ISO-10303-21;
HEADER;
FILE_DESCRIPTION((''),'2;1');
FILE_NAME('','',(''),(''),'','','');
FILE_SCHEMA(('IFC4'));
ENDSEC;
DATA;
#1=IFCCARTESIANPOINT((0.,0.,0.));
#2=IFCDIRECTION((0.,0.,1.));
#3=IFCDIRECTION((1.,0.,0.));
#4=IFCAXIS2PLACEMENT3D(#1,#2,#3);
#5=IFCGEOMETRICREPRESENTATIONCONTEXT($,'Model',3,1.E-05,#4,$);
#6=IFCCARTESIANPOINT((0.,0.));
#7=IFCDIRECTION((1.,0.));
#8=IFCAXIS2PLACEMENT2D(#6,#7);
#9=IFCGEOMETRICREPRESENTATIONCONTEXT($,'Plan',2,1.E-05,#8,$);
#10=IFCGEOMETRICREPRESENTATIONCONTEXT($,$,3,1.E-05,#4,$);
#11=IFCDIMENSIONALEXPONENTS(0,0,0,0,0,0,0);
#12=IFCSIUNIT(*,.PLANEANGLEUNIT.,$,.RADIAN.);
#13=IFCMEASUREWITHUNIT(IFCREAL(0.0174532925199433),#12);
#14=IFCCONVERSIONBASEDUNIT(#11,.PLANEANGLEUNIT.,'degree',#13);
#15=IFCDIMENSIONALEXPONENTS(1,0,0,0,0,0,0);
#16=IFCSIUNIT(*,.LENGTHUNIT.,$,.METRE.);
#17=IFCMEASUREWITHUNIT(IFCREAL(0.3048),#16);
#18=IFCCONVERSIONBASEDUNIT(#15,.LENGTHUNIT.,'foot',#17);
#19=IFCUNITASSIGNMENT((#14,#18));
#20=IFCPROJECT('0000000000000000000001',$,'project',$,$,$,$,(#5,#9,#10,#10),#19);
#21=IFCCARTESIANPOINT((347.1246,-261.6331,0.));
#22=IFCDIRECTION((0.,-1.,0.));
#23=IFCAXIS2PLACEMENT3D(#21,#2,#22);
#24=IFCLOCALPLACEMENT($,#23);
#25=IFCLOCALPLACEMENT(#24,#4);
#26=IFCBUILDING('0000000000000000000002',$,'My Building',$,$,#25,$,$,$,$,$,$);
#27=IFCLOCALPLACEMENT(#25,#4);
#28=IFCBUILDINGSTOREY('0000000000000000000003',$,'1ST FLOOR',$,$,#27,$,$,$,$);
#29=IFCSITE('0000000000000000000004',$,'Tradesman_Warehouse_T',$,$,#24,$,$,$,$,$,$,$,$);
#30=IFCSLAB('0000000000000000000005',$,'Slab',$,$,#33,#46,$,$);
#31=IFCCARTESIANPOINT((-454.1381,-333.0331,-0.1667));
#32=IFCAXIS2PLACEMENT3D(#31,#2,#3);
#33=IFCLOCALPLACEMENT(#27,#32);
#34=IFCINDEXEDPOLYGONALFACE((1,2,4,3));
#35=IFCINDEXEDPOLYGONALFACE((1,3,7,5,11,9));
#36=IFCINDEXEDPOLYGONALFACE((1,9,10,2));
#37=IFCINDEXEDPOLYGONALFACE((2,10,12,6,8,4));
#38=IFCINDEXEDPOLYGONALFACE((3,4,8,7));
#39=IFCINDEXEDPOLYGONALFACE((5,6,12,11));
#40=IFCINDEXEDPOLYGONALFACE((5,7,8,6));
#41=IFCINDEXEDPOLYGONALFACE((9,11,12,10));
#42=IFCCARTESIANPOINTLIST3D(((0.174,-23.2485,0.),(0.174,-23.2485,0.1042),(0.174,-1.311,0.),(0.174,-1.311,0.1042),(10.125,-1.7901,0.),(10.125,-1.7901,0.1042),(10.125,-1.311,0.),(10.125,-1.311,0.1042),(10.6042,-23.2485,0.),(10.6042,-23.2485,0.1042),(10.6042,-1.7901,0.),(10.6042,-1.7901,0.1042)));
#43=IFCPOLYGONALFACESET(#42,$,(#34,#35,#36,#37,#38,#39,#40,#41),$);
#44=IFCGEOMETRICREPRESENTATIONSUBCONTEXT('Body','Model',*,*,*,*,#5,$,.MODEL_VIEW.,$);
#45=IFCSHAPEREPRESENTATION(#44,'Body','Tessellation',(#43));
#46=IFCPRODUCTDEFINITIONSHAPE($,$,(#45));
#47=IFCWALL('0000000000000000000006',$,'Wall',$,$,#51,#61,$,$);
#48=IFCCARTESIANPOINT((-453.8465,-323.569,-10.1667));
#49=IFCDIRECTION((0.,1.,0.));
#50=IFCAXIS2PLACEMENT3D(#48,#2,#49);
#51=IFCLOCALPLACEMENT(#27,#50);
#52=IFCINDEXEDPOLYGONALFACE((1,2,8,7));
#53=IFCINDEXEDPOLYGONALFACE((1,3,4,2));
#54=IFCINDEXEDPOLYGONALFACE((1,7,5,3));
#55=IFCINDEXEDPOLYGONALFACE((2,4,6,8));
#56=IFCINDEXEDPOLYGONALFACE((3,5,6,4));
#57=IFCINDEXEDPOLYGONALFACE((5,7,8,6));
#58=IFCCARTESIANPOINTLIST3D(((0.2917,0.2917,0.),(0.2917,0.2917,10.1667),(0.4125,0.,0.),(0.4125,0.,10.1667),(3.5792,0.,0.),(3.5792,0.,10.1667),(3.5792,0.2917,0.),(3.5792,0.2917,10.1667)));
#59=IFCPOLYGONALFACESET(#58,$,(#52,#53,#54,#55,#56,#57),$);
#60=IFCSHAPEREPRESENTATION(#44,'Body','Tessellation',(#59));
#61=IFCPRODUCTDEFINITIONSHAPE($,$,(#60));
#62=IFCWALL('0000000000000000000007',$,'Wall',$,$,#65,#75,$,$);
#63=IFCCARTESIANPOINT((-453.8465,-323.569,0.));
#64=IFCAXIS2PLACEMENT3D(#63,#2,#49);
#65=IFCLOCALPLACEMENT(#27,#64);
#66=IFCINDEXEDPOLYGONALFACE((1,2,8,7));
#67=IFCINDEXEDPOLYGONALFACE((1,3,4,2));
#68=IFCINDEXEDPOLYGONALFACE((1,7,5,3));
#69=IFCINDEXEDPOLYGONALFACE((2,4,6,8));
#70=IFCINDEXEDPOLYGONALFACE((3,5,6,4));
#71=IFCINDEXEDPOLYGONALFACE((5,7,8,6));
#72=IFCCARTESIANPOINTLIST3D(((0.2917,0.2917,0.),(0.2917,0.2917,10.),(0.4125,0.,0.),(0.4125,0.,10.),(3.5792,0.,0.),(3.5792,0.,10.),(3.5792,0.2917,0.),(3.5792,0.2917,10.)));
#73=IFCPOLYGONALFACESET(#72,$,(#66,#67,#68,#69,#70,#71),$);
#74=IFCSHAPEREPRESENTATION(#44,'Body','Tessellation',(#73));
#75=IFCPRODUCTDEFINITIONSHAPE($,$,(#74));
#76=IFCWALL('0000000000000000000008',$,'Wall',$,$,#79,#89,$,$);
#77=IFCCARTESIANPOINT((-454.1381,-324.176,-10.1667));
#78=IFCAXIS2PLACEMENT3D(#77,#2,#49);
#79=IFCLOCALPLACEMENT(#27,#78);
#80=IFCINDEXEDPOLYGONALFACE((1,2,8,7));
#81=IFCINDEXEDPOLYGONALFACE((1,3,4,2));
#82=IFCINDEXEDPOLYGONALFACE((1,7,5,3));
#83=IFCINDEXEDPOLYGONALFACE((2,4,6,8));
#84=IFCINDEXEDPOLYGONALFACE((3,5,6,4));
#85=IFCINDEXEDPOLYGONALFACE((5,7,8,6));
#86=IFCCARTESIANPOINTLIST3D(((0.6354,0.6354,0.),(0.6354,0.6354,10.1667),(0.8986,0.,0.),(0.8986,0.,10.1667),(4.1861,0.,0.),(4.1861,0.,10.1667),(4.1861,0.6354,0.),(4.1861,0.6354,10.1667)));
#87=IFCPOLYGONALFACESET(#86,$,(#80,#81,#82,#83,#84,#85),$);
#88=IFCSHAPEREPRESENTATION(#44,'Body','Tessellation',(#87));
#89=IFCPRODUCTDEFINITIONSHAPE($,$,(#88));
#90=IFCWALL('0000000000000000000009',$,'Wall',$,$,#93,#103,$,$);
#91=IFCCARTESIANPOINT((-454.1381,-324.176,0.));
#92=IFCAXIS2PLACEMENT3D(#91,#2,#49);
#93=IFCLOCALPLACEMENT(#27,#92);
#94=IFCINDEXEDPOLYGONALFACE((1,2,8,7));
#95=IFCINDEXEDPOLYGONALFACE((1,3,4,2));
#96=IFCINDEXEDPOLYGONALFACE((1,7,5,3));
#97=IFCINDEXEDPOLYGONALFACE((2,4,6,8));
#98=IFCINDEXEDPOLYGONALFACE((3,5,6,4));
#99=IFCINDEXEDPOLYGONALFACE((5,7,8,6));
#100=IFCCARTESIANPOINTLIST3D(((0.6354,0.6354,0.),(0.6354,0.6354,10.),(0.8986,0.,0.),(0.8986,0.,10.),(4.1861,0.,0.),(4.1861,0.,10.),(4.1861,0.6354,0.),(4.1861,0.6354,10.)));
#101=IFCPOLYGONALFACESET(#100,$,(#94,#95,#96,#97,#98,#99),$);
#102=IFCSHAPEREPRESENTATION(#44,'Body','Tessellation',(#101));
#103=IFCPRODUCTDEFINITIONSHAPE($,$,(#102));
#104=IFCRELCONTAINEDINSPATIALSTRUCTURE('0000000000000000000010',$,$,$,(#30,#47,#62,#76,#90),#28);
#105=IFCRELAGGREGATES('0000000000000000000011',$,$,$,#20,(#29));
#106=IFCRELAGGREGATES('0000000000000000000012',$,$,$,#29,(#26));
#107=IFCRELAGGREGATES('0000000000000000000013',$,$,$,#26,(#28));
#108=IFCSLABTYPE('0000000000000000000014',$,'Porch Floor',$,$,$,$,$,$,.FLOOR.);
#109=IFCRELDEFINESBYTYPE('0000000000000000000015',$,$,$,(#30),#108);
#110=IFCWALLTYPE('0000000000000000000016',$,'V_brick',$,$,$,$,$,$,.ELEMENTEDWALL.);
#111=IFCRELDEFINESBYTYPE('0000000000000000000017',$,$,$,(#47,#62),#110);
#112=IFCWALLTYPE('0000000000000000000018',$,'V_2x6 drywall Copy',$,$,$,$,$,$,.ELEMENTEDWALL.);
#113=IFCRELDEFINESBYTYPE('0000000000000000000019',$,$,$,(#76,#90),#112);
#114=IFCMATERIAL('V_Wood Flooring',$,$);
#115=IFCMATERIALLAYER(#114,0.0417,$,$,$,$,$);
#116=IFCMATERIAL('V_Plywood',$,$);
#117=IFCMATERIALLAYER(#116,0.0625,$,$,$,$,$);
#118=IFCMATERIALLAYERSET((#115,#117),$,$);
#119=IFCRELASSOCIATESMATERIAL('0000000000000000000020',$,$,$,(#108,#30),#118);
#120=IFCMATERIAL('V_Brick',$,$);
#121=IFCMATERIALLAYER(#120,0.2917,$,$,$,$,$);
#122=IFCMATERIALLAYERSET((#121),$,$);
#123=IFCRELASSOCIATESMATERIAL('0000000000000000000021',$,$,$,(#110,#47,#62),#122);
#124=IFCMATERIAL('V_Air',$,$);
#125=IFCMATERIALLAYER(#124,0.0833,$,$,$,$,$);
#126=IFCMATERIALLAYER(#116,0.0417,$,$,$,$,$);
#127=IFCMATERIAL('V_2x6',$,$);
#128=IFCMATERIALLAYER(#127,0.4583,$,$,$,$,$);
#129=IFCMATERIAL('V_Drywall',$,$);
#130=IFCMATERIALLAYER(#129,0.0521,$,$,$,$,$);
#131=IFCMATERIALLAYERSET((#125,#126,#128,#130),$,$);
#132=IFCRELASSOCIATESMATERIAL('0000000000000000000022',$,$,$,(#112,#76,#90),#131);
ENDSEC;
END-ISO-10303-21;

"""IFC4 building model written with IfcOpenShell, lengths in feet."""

from ifc_helpers import new_model, entity, si_unit, converted_unit, frame, origin_with_axes, origin_2d_with_axis, place, context, subcontext, project, spatial, indexed_curve, outline, extrude, clip, halfspace, material, layer, layer_set, layer_usage, type_object, element, save


model = new_model("IFC4")

# Units and contexts
model_context = context("Model", 3, precision=1e-05, world=origin_with_axes())
plan_context = context("Plan", 2, precision=1e-05, world=origin_2d_with_axis())
context_of_model = context(None, 3, precision=1e-05, world=origin_with_axes())
body_context = subcontext(model_context, "Body", "Model", "MODEL_VIEW")
ifc_project = project(units=[converted_unit("PLANEANGLEUNIT", "degree", entity("IfcReal", 0.0174532925199433), si_unit("PLANEANGLEUNIT", "RADIAN"), dimensions=[0, 0, 0, 0, 0, 0, 0]), converted_unit("LENGTHUNIT", "foot", entity("IfcReal", 0.3048), si_unit("LENGTHUNIT", "METRE"), dimensions=[1, 0, 0, 0, 0, 0, 0])], contexts=[model_context, plan_context, context_of_model, context_of_model])

# Site, building, storey
site_placement = place(None, frame((347.1246, -261.6331, 0.0), z_axis=(0.0, 0.0, 1.0), x_axis=(0.0, -1.0, 0.0)))
site = spatial("IfcSite", under=ifc_project, at=site_placement, Name="Tradesman_Warehouse_T")
building_placement = place(site_placement, frame((0.0, 0.0, 0.0), z_axis=(0.0, 0.0, 1.0), x_axis=(1.0, 0.0, 0.0)))
building = spatial("IfcBuilding", under=site, at=building_placement, Name="My Building")
storey_placement = place(building_placement, frame((0.0, 0.0, 0.0), z_axis=(0.0, 0.0, 1.0), x_axis=(1.0, 0.0, 0.0)))
storey = spatial("IfcBuildingStorey", under=building, at=storey_placement, Name="1ST FLOOR")

# Slab
ifc_material_1 = material(Name="V_Wood Flooring")
ifc_layer_1 = layer(ifc_material_1, 0.0417)
ifc_material_2 = material(Name="V_Plywood")
ifc_layer_2 = layer(ifc_material_2, 0.0625)
ifc_layer_set_1 = layer_set([ifc_layer_1, ifc_layer_2])
ifc_layer_usage_1 = layer_usage(ifc_layer_set_1, "AXIS3", "POSITIVE", 0.0)
slab_type = type_object("IfcSlabType", Name="Porch Floor", PredefinedType="FLOOR", material=ifc_layer_set_1)
slab_placement = place(storey_placement, frame((-454.1381, -333.0331, -0.1667), z_axis=(0.0, 0.0, 1.0), x_axis=(1.0, 0.0, 0.0)))
element("IfcSlab", 1, at=slab_placement, inside=storey, type_object=slab_type, material=ifc_layer_usage_1, Name="Slab", context=body_context, shape_type="SweptSolid", body=[
    extrude(outline(indexed_curve([(10.125, -1.311), (0.174, -1.311), (0.174, -23.2485), (10.6042, -23.2485), (10.6042, -1.7901), (10.125, -1.7901), (10.125, -1.311)])), None, (0.0, 0.0, 1.0), 0.1042),
])

# Walls
ifc_material_3 = material(Name="V_Brick")
ifc_layer_3 = layer(ifc_material_3, 0.2917)
ifc_layer_set_2 = layer_set([ifc_layer_3])
ifc_layer_usage_2 = layer_usage(ifc_layer_set_2, "AXIS2", "POSITIVE", 0.0)
wall_type_1 = type_object("IfcWallType", Name="V_brick", PredefinedType="ELEMENTEDWALL", material=ifc_layer_set_2)
wall_1_placement = place(storey_placement, frame((-453.8465, -323.569, -10.1667), z_axis=(0.0, 0.0, 1.0), x_axis=(0.0, 1.0, 0.0)))
element("IfcWall", 2, at=wall_1_placement, inside=storey, type_object=wall_type_1, material=ifc_layer_usage_2, Name="Wall", context=body_context, shape_type="Clipping", body=[
    clip(extrude(outline(indexed_curve([(0.0, 0.0), (0.0, 0.2917), (3.5792, 0.2917), (3.5792, 0.0), (0.0, 0.0)], self_intersect=False)), origin_with_axes(), (0.0, 0.0, 1.0), 10.1667), halfspace(frame((0.4125, 0.0, 10.1667), z_axis=(-0.923871, -0.382705, 0.0), x_axis=(-0.382705, 0.923871, 0.0)), False)),
])
ifc_layer_usage_3 = layer_usage(ifc_layer_set_2, "AXIS2", "POSITIVE", 0.0)
wall_2_placement = place(storey_placement, frame((-453.8465, -323.569, 0.0), z_axis=(0.0, 0.0, 1.0), x_axis=(0.0, 1.0, 0.0)))
element("IfcWall", 3, at=wall_2_placement, inside=storey, type_object=wall_type_1, material=ifc_layer_usage_3, Name="Wall", context=body_context, shape_type="Clipping", body=[
    clip(extrude(outline(indexed_curve([(0.0, 0.0), (0.0, 0.2917), (3.5792, 0.2917), (3.5792, 0.0), (0.0, 0.0)], self_intersect=False)), origin_with_axes(), (0.0, 0.0, 1.0), 10.0), halfspace(frame((0.4125, 0.0, 0.0), z_axis=(-0.923871, -0.382705, 0.0), x_axis=(-0.382705, 0.923871, 0.0)), False)),
])
ifc_material_4 = material(Name="V_Air")
ifc_layer_4 = layer(ifc_material_4, 0.0833)
ifc_layer_5 = layer(ifc_material_2, 0.0417)
ifc_material_5 = material(Name="V_2x6")
ifc_layer_6 = layer(ifc_material_5, 0.4583)
ifc_material_6 = material(Name="V_Drywall")
ifc_layer_7 = layer(ifc_material_6, 0.0521)
ifc_layer_set_3 = layer_set([ifc_layer_4, ifc_layer_5, ifc_layer_6, ifc_layer_7])
ifc_layer_usage_4 = layer_usage(ifc_layer_set_3, "AXIS2", "POSITIVE", 0.0)
wall_type_2 = type_object("IfcWallType", Name="V_2x6 drywall Copy", PredefinedType="ELEMENTEDWALL", material=ifc_layer_set_3)
wall_3_placement = place(storey_placement, frame((-454.1381, -324.176, -10.1667), z_axis=(0.0, 0.0, 1.0), x_axis=(0.0, 1.0, 0.0)))
element("IfcWall", 4, at=wall_3_placement, inside=storey, type_object=wall_type_2, material=ifc_layer_usage_4, Name="Wall", context=body_context, shape_type="Clipping", body=[
    clip(extrude(outline(indexed_curve([(0.0, 0.0), (0.0, 0.6354), (4.1861, 0.6354), (4.1861, 0.0), (0.0, 0.0)], self_intersect=False)), origin_with_axes(), (0.0, 0.0, 1.0), 10.1667), halfspace(frame((0.8986, 0.0, 10.1667), z_axis=(-0.923893, -0.382652, 0.0), x_axis=(-0.382652, 0.923893, 0.0)), False)),
])
ifc_layer_usage_5 = layer_usage(ifc_layer_set_3, "AXIS2", "POSITIVE", 0.0)
wall_4_placement = place(storey_placement, frame((-454.1381, -324.176, 0.0), z_axis=(0.0, 0.0, 1.0), x_axis=(0.0, 1.0, 0.0)))
element("IfcWall", 5, at=wall_4_placement, inside=storey, type_object=wall_type_2, material=ifc_layer_usage_5, Name="Wall", context=body_context, shape_type="Clipping", body=[
    clip(extrude(outline(indexed_curve([(0.0, 0.0), (0.0, 0.6354), (4.1861, 0.6354), (4.1861, 0.0), (0.0, 0.0)], self_intersect=False)), origin_with_axes(), (0.0, 0.0, 1.0), 10.0), halfspace(frame((0.8986, 0.0, 0.0), z_axis=(-0.92388, -0.382683, 0.0), x_axis=(-0.382683, 0.92388, 0.0)), False)),
])

save(model, "model.ifc")
